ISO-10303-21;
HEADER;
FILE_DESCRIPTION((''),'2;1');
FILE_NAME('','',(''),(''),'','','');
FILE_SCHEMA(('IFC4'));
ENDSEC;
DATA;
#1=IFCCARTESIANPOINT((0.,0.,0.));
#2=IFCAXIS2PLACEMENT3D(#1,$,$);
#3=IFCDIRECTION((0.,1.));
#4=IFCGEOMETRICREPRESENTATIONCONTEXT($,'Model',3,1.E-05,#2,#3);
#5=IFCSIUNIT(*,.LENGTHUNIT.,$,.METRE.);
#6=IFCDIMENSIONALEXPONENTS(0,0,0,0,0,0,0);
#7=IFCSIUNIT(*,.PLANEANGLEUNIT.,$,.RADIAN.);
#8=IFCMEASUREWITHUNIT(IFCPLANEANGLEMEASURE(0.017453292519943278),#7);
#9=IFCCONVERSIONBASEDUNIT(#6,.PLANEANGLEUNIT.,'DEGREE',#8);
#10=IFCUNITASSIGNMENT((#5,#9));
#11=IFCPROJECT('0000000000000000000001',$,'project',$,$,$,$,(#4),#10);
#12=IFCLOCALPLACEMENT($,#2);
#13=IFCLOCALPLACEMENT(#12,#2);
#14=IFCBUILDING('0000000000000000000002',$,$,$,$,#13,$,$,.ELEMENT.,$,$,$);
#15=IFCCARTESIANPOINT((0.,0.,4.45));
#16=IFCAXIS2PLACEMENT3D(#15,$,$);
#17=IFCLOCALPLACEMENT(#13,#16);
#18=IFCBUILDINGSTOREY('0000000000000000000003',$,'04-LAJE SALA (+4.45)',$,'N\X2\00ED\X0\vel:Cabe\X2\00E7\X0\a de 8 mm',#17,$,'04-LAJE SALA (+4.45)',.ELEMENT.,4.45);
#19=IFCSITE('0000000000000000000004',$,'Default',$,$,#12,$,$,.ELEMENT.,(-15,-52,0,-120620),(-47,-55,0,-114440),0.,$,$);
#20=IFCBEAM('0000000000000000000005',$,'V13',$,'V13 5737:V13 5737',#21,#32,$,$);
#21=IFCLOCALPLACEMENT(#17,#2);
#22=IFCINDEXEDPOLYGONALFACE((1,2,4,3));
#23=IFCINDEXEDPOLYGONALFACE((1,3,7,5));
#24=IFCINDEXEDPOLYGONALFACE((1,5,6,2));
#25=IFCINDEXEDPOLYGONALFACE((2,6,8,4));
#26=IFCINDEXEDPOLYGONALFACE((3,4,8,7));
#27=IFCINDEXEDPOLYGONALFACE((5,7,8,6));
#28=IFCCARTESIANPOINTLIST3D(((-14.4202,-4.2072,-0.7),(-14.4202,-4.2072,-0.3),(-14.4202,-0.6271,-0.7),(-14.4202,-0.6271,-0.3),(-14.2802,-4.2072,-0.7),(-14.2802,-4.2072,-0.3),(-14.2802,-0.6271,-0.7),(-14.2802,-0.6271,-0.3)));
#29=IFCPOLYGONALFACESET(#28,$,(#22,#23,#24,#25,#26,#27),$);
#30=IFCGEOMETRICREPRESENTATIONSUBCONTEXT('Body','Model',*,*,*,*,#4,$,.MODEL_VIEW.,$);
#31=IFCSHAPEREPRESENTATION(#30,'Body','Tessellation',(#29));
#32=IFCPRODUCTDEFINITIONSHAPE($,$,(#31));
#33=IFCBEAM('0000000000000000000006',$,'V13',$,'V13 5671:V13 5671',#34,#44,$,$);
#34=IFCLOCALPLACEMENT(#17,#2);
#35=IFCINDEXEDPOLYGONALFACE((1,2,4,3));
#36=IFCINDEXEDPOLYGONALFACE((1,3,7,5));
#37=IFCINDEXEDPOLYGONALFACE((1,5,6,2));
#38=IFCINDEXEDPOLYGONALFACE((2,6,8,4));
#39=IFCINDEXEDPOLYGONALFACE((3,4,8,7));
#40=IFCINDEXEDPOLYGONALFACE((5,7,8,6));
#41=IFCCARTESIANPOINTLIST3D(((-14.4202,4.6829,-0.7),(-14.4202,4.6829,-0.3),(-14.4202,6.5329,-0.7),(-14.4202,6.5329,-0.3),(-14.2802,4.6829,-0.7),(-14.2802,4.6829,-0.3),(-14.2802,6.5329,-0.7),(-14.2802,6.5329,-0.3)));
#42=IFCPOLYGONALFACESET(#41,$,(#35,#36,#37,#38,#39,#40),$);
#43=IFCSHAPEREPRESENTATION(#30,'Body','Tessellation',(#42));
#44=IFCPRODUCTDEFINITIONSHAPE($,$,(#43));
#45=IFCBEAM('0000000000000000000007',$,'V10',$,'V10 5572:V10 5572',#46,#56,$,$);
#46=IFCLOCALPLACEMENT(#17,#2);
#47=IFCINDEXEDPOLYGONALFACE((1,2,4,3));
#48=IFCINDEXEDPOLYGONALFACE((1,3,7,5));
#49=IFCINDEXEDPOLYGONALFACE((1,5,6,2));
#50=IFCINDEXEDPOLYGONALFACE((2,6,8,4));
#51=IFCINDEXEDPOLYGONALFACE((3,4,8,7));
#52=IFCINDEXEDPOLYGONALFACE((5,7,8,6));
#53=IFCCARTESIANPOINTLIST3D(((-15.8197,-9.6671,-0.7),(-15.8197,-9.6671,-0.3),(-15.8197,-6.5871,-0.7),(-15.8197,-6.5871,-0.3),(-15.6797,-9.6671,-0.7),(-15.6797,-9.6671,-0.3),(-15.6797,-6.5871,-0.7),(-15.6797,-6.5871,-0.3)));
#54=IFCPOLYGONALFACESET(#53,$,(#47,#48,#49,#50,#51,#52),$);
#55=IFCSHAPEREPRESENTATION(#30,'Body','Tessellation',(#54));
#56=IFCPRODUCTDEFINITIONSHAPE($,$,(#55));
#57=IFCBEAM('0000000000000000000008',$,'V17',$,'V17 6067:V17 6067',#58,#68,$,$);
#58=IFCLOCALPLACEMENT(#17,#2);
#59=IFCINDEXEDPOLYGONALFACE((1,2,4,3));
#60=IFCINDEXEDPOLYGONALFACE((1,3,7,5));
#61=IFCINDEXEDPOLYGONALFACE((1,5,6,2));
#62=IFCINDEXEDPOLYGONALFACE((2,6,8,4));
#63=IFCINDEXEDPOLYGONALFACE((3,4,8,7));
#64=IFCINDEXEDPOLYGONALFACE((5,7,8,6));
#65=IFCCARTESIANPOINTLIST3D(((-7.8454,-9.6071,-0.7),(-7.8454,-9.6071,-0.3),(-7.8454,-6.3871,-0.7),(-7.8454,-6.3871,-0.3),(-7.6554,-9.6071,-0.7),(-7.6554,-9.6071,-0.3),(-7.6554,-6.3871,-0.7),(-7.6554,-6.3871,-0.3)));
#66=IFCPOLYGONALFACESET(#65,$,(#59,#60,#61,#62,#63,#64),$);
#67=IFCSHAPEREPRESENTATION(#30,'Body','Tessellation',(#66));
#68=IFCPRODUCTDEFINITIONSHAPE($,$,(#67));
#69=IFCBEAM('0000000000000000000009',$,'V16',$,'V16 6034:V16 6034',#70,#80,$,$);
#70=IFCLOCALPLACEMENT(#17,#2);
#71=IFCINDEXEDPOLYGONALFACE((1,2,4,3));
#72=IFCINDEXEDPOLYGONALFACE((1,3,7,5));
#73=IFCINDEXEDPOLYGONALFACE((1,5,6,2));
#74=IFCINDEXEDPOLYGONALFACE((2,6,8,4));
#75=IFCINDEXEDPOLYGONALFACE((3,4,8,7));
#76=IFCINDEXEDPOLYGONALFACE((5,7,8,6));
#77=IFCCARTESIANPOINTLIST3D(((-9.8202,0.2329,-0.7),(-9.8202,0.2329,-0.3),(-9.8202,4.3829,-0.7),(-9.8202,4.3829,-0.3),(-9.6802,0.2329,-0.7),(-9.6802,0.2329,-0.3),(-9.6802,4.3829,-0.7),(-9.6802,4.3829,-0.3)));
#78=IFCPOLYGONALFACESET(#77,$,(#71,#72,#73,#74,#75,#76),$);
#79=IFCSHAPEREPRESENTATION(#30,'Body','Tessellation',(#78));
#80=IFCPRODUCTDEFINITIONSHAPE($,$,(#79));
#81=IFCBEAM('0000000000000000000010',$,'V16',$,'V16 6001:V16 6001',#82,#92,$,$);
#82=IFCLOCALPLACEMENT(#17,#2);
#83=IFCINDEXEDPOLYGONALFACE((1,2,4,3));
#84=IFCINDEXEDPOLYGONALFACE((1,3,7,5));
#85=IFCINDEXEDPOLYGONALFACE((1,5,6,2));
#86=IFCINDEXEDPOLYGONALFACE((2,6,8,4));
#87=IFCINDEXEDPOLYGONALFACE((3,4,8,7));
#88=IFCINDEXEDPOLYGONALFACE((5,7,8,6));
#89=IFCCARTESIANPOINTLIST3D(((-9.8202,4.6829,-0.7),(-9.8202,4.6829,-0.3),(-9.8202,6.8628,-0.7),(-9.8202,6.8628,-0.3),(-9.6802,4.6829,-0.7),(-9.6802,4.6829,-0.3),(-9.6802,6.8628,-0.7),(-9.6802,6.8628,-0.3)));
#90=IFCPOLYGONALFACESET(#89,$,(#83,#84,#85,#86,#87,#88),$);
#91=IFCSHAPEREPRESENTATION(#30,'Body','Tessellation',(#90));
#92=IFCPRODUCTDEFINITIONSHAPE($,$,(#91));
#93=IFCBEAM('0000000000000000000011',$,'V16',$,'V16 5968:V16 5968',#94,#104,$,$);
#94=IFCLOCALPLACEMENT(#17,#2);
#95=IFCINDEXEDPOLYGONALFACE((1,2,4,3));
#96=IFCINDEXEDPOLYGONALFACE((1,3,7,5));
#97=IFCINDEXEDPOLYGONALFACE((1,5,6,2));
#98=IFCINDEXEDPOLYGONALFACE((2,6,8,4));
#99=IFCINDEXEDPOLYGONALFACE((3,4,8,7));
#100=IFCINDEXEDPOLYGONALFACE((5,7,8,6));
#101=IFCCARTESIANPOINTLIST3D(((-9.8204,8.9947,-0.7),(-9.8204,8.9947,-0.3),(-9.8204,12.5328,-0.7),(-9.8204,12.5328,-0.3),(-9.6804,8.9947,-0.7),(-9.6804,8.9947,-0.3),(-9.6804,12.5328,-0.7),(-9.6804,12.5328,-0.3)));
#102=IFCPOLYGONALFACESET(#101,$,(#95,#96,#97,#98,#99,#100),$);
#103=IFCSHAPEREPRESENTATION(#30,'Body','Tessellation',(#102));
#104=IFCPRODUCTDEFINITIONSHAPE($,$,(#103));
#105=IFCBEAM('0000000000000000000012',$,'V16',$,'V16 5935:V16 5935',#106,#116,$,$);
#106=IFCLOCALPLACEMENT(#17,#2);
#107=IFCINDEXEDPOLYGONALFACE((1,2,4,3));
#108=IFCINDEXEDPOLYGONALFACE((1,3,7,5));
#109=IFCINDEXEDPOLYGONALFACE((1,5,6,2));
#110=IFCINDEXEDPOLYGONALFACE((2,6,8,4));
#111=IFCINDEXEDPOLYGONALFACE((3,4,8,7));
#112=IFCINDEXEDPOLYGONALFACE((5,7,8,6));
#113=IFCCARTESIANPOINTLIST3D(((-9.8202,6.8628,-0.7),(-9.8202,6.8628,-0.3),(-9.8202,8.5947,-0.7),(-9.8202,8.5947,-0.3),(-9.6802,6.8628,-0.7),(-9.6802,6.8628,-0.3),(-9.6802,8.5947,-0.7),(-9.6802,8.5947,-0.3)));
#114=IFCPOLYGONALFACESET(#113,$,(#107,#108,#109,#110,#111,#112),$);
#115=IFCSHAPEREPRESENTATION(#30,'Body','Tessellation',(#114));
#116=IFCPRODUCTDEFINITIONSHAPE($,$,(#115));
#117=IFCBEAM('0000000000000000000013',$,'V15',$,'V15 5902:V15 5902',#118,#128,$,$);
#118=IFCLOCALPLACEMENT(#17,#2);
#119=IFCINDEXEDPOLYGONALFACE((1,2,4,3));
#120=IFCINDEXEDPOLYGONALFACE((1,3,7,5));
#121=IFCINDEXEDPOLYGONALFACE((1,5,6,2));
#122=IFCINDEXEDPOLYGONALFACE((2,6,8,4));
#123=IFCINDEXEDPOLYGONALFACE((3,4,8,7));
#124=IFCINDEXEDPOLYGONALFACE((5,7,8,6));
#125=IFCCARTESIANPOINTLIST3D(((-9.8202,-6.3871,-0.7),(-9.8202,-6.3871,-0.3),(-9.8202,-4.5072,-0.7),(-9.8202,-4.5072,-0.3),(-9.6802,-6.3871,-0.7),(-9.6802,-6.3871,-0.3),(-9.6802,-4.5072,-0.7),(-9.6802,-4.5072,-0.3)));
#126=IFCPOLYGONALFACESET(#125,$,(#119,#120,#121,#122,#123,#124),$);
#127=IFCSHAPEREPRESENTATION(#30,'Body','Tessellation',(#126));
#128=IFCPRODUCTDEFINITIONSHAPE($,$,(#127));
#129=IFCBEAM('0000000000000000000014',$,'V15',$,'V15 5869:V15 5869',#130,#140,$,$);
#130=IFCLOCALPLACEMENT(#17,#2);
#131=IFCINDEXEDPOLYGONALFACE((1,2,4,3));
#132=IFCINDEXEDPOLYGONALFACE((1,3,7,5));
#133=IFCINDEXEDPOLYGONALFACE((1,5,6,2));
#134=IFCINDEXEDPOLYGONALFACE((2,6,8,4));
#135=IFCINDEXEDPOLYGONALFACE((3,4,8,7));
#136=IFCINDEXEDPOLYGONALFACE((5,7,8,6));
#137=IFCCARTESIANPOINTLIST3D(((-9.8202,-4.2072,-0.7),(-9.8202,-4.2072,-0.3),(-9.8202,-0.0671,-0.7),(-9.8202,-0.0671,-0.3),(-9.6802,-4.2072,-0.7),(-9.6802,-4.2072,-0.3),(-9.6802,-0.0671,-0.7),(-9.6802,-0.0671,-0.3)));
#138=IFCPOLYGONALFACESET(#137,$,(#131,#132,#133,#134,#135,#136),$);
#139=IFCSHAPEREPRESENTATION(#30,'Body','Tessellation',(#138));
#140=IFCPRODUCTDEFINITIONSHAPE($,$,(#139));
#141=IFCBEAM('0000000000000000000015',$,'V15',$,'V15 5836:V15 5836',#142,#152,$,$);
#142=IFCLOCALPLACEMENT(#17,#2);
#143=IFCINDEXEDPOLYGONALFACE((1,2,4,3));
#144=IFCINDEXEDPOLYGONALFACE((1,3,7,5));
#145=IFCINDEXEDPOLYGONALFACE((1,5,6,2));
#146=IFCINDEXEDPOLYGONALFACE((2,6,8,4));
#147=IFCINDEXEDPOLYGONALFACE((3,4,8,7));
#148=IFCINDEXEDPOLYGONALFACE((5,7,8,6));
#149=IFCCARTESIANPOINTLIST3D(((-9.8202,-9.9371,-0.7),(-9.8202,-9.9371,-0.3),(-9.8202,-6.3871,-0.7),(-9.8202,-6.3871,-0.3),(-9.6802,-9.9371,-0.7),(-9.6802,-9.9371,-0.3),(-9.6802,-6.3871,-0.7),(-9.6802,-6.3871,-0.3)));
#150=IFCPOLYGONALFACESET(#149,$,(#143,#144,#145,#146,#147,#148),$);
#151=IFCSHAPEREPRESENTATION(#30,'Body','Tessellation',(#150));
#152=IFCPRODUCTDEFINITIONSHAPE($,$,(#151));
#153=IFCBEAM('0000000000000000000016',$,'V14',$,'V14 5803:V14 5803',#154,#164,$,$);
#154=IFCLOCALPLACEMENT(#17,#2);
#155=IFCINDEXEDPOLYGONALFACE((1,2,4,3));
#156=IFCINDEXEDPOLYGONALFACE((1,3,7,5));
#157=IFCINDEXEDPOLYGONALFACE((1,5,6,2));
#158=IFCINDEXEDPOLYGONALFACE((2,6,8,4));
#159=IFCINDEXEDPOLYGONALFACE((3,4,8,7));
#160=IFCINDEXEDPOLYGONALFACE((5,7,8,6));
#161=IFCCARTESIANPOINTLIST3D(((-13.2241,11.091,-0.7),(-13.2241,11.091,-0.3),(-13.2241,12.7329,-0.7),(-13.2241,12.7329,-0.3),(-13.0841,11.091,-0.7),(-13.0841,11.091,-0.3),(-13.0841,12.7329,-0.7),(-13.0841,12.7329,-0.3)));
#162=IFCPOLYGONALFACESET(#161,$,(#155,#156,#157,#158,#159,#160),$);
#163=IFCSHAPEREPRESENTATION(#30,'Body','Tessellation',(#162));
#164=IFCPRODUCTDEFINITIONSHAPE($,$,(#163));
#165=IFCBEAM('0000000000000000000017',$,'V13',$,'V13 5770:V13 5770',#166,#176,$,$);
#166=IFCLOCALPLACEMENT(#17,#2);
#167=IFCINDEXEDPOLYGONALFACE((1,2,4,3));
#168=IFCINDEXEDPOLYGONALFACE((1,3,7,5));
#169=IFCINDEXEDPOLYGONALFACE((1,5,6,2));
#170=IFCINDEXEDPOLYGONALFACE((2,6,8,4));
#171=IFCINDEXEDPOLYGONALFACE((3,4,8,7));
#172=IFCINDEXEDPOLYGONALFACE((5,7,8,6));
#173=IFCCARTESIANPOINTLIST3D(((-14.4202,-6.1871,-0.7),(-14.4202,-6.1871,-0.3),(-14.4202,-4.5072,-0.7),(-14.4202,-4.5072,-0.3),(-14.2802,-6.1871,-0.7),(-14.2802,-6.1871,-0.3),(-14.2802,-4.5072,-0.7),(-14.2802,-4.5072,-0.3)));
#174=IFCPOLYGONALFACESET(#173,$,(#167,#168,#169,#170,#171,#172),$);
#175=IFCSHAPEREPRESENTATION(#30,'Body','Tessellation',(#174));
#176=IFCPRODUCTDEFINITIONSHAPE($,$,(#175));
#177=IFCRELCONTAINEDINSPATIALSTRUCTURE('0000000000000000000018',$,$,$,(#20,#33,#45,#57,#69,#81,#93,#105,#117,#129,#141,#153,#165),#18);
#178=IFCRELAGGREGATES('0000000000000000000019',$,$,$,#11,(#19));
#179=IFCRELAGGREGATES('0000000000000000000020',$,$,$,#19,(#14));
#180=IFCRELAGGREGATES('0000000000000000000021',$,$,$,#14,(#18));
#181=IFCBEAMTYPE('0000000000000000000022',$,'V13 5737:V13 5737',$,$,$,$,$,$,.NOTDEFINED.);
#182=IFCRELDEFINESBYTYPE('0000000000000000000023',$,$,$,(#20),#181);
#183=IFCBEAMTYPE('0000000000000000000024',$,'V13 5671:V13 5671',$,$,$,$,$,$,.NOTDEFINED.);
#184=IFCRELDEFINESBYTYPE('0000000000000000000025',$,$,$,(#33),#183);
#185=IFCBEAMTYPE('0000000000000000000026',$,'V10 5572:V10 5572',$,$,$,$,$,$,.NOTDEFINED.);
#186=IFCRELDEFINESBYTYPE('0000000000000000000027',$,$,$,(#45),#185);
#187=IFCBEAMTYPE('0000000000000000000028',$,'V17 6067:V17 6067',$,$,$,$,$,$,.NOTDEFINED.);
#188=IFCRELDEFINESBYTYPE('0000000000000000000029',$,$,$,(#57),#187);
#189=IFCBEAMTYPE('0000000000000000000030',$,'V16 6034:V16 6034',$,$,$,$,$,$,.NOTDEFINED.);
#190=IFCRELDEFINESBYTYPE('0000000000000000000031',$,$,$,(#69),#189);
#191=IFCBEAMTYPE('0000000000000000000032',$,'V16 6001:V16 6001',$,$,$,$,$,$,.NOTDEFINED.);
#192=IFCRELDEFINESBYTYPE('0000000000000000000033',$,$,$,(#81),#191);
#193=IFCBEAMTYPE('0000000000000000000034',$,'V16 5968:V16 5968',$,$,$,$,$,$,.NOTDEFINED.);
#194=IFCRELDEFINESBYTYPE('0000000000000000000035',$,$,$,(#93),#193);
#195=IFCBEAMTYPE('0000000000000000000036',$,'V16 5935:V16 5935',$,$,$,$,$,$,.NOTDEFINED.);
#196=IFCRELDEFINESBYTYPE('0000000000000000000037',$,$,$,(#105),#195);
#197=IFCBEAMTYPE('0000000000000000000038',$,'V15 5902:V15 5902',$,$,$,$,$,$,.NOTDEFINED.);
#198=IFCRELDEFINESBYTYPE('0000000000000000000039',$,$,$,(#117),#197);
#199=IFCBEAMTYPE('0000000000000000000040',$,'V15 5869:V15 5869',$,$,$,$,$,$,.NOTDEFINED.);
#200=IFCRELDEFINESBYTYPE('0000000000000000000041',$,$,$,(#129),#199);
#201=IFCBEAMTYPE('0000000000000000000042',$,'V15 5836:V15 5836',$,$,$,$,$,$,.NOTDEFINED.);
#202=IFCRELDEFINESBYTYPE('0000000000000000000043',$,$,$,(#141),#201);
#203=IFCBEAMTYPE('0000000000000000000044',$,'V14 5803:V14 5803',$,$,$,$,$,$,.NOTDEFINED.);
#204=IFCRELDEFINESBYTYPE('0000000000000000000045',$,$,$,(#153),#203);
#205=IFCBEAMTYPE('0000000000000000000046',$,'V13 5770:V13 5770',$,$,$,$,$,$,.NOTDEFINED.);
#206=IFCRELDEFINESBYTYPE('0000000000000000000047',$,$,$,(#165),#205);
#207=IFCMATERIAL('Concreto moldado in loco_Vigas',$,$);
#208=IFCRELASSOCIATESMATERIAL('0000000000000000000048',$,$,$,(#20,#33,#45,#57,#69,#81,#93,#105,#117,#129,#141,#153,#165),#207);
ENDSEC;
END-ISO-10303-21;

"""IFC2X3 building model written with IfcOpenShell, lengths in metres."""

from ifc_helpers import new_model, entity, si_unit, converted_unit, direction, frame, frame_2d, origin, place, context, subcontext, project, spatial, rectangle, extrude, material, type_object, element, save


model = new_model("IFC2X3")

# Units and contexts
model_context = context("Model", 3, precision=1e-05, world=origin(), true_north=direction((0.0, 1.0)))
body_context = subcontext(model_context, "Body", "Model", "MODEL_VIEW")
ifc_project = project(units=[si_unit("LENGTHUNIT", "METRE"), converted_unit("PLANEANGLEUNIT", "DEGREE", entity("IfcPlaneAngleMeasure", 0.017453292519943278), si_unit("PLANEANGLEUNIT", "RADIAN"), dimensions=[0, 0, 0, 0, 0, 0, 0])], contexts=[model_context])

# Site, building, storey
site_placement = place(None, origin())
site = spatial("IfcSite", under=ifc_project, at=site_placement, Name="Default", CompositionType="ELEMENT", RefLatitude=(-15, -52, 0, -120620), RefLongitude=(-47, -55, 0, -114440), RefElevation=0.0)
building_placement = place(site_placement, origin())
building = spatial("IfcBuilding", under=site, at=building_placement, CompositionType="ELEMENT")
storey_placement = place(building_placement, frame((0.0, 0.0, 4.45)))
storey = spatial("IfcBuildingStorey", under=building, at=storey_placement, Name="04-LAJE SALA (+4.45)", ObjectType="Nível:Cabeça de 8 mm", LongName="04-LAJE SALA (+4.45)", CompositionType="ELEMENT", Elevation=4.45)

# Beams
ifc_material_1 = material(Name="Concreto moldado in loco_Vigas")
beam_type_1 = type_object("IfcBeamType", Name="V13 5737:V13 5737", PredefinedType="NOTDEFINED")
beam_1_placement = place(storey_placement, origin())
element("IfcBeam", 1, at=beam_1_placement, inside=storey, type_object=beam_type_1, material=ifc_material_1, Name="V13", ObjectType="V13 5737:V13 5737", context=body_context, shape_type="SweptSolid", body=[
    extrude(rectangle(XDim=0.4, YDim=3.5801, at=frame_2d((0.0, 0.0), x_axis=(0.0, 1.0))), frame((-14.4202, -2.4171, -0.5), z_axis=(1.0, 0.0, 0.0), x_axis=(0.0, -1.0, 0.0)), (0.0, 0.0, 1.0), 0.14),
])
beam_type_2 = type_object("IfcBeamType", Name="V13 5671:V13 5671", PredefinedType="NOTDEFINED")
beam_2_placement = place(storey_placement, origin())
element("IfcBeam", 2, at=beam_2_placement, inside=storey, type_object=beam_type_2, material=ifc_material_1, Name="V13", ObjectType="V13 5671:V13 5671", context=body_context, shape_type="SweptSolid", body=[
    extrude(rectangle(XDim=0.4, YDim=1.85, at=frame_2d((0.0, 0.0), x_axis=(0.0, 1.0))), frame((-14.4202, 5.6079, -0.5), z_axis=(1.0, 0.0, 0.0), x_axis=(0.0, -1.0, 0.0)), (0.0, 0.0, 1.0), 0.14),
])
beam_type_3 = type_object("IfcBeamType", Name="V10 5572:V10 5572", PredefinedType="NOTDEFINED")
beam_3_placement = place(storey_placement, origin())
element("IfcBeam", 3, at=beam_3_placement, inside=storey, type_object=beam_type_3, material=ifc_material_1, Name="V10", ObjectType="V10 5572:V10 5572", context=body_context, shape_type="SweptSolid", body=[
    extrude(rectangle(XDim=0.4, YDim=3.08, at=frame_2d((0.0, 0.0), x_axis=(0.0, 1.0))), frame((-15.8197, -8.1271, -0.5), z_axis=(1.0, 0.0, 0.0), x_axis=(0.0, -1.0, 0.0)), (0.0, 0.0, 1.0), 0.14),
])
beam_type_4 = type_object("IfcBeamType", Name="V17 6067:V17 6067", PredefinedType="NOTDEFINED")
beam_4_placement = place(storey_placement, origin())
element("IfcBeam", 4, at=beam_4_placement, inside=storey, type_object=beam_type_4, material=ifc_material_1, Name="V17", ObjectType="V17 6067:V17 6067", context=body_context, shape_type="SweptSolid", body=[
    extrude(rectangle(XDim=0.4, YDim=3.22, at=frame_2d((0.0, 0.0), x_axis=(0.0, 1.0))), frame((-7.8454, -7.9971, -0.5), z_axis=(1.0, 0.0, 0.0), x_axis=(0.0, -1.0, 0.0)), (0.0, 0.0, 1.0), 0.19),
])
beam_type_5 = type_object("IfcBeamType", Name="V16 6034:V16 6034", PredefinedType="NOTDEFINED")
beam_5_placement = place(storey_placement, origin())
element("IfcBeam", 5, at=beam_5_placement, inside=storey, type_object=beam_type_5, material=ifc_material_1, Name="V16", ObjectType="V16 6034:V16 6034", context=body_context, shape_type="SweptSolid", body=[
    extrude(rectangle(XDim=0.4, YDim=4.15, at=frame_2d((0.0, 0.0), x_axis=(0.0, 1.0))), frame((-9.8202, 2.3079, -0.5), z_axis=(1.0, 0.0, 0.0), x_axis=(0.0, -1.0, 0.0)), (0.0, 0.0, 1.0), 0.14),
])
beam_type_6 = type_object("IfcBeamType", Name="V16 6001:V16 6001", PredefinedType="NOTDEFINED")
beam_6_placement = place(storey_placement, origin())
element("IfcBeam", 6, at=beam_6_placement, inside=storey, type_object=beam_type_6, material=ifc_material_1, Name="V16", ObjectType="V16 6001:V16 6001", context=body_context, shape_type="SweptSolid", body=[
    extrude(rectangle(XDim=0.4, YDim=2.1799, at=frame_2d((0.0, 0.0), x_axis=(0.0, 1.0))), frame((-9.8202, 5.7729, -0.5), z_axis=(1.0, 0.0, 0.0), x_axis=(0.0, -1.0, 0.0)), (0.0, 0.0, 1.0), 0.14),
])
beam_type_7 = type_object("IfcBeamType", Name="V16 5968:V16 5968", PredefinedType="NOTDEFINED")
beam_7_placement = place(storey_placement, origin())
element("IfcBeam", 7, at=beam_7_placement, inside=storey, type_object=beam_type_7, material=ifc_material_1, Name="V16", ObjectType="V16 5968:V16 5968", context=body_context, shape_type="SweptSolid", body=[
    extrude(rectangle(XDim=0.4, YDim=3.5381, at=frame_2d((0.0, 0.0), x_axis=(0.0, 1.0))), frame((-9.8204, 10.7638, -0.5), z_axis=(1.0, 0.0, 0.0), x_axis=(0.0, -1.0, 0.0)), (0.0, 0.0, 1.0), 0.14),
])
beam_type_8 = type_object("IfcBeamType", Name="V16 5935:V16 5935", PredefinedType="NOTDEFINED")
beam_8_placement = place(storey_placement, origin())
element("IfcBeam", 8, at=beam_8_placement, inside=storey, type_object=beam_type_8, material=ifc_material_1, Name="V16", ObjectType="V16 5935:V16 5935", context=body_context, shape_type="SweptSolid", body=[
    extrude(rectangle(XDim=0.4, YDim=1.7319, at=frame_2d((0.0, 0.0), x_axis=(0.0, 1.0))), frame((-9.8202, 7.7288, -0.5), z_axis=(1.0, 0.0, 0.0), x_axis=(0.0, -1.0, 0.0)), (0.0, 0.0, 1.0), 0.14),
])
beam_type_9 = type_object("IfcBeamType", Name="V15 5902:V15 5902", PredefinedType="NOTDEFINED")
beam_9_placement = place(storey_placement, origin())
element("IfcBeam", 9, at=beam_9_placement, inside=storey, type_object=beam_type_9, material=ifc_material_1, Name="V15", ObjectType="V15 5902:V15 5902", context=body_context, shape_type="SweptSolid", body=[
    extrude(rectangle(XDim=0.4, YDim=1.8799, at=frame_2d((0.0, 0.0), x_axis=(0.0, 1.0))), frame((-9.8202, -5.4471, -0.5), z_axis=(1.0, 0.0, 0.0), x_axis=(0.0, -1.0, 0.0)), (0.0, 0.0, 1.0), 0.14),
])
beam_type_10 = type_object("IfcBeamType", Name="V15 5869:V15 5869", PredefinedType="NOTDEFINED")
beam_10_placement = place(storey_placement, origin())
element("IfcBeam", 10, at=beam_10_placement, inside=storey, type_object=beam_type_10, material=ifc_material_1, Name="V15", ObjectType="V15 5869:V15 5869", context=body_context, shape_type="SweptSolid", body=[
    extrude(rectangle(XDim=0.4, YDim=4.1401, at=frame_2d((0.0, 0.0), x_axis=(0.0, 1.0))), frame((-9.8202, -2.1371, -0.5), z_axis=(1.0, 0.0, 0.0), x_axis=(0.0, -1.0, 0.0)), (0.0, 0.0, 1.0), 0.14),
])
beam_type_11 = type_object("IfcBeamType", Name="V15 5836:V15 5836", PredefinedType="NOTDEFINED")
beam_11_placement = place(storey_placement, origin())
element("IfcBeam", 11, at=beam_11_placement, inside=storey, type_object=beam_type_11, material=ifc_material_1, Name="V15", ObjectType="V15 5836:V15 5836", context=body_context, shape_type="SweptSolid", body=[
    extrude(rectangle(XDim=0.4, YDim=3.55, at=frame_2d((0.0, 0.0), x_axis=(0.0, 1.0))), frame((-9.8202, -8.1621, -0.5), z_axis=(1.0, 0.0, 0.0), x_axis=(0.0, -1.0, 0.0)), (0.0, 0.0, 1.0), 0.14),
])
beam_type_12 = type_object("IfcBeamType", Name="V14 5803:V14 5803", PredefinedType="NOTDEFINED")
beam_12_placement = place(storey_placement, origin())
element("IfcBeam", 12, at=beam_12_placement, inside=storey, type_object=beam_type_12, material=ifc_material_1, Name="V14", ObjectType="V14 5803:V14 5803", context=body_context, shape_type="SweptSolid", body=[
    extrude(rectangle(XDim=0.4, YDim=1.6419, at=frame_2d((0.0, 0.0), x_axis=(0.0, 1.0))), frame((-13.2241, 11.912, -0.5), z_axis=(1.0, 0.0, 0.0), x_axis=(0.0, -1.0, 0.0)), (0.0, 0.0, 1.0), 0.14),
])
beam_type_13 = type_object("IfcBeamType", Name="V13 5770:V13 5770", PredefinedType="NOTDEFINED")
beam_13_placement = place(storey_placement, origin())
element("IfcBeam", 13, at=beam_13_placement, inside=storey, type_object=beam_type_13, material=ifc_material_1, Name="V13", ObjectType="V13 5770:V13 5770", context=body_context, shape_type="SweptSolid", body=[
    extrude(rectangle(XDim=0.4, YDim=1.6799, at=frame_2d((0.0, 0.0), x_axis=(0.0, 1.0))), frame((-14.4202, -5.3471, -0.5), z_axis=(1.0, 0.0, 0.0), x_axis=(0.0, -1.0, 0.0)), (0.0, 0.0, 1.0), 0.14),
])

save(model, "model.ifc")
